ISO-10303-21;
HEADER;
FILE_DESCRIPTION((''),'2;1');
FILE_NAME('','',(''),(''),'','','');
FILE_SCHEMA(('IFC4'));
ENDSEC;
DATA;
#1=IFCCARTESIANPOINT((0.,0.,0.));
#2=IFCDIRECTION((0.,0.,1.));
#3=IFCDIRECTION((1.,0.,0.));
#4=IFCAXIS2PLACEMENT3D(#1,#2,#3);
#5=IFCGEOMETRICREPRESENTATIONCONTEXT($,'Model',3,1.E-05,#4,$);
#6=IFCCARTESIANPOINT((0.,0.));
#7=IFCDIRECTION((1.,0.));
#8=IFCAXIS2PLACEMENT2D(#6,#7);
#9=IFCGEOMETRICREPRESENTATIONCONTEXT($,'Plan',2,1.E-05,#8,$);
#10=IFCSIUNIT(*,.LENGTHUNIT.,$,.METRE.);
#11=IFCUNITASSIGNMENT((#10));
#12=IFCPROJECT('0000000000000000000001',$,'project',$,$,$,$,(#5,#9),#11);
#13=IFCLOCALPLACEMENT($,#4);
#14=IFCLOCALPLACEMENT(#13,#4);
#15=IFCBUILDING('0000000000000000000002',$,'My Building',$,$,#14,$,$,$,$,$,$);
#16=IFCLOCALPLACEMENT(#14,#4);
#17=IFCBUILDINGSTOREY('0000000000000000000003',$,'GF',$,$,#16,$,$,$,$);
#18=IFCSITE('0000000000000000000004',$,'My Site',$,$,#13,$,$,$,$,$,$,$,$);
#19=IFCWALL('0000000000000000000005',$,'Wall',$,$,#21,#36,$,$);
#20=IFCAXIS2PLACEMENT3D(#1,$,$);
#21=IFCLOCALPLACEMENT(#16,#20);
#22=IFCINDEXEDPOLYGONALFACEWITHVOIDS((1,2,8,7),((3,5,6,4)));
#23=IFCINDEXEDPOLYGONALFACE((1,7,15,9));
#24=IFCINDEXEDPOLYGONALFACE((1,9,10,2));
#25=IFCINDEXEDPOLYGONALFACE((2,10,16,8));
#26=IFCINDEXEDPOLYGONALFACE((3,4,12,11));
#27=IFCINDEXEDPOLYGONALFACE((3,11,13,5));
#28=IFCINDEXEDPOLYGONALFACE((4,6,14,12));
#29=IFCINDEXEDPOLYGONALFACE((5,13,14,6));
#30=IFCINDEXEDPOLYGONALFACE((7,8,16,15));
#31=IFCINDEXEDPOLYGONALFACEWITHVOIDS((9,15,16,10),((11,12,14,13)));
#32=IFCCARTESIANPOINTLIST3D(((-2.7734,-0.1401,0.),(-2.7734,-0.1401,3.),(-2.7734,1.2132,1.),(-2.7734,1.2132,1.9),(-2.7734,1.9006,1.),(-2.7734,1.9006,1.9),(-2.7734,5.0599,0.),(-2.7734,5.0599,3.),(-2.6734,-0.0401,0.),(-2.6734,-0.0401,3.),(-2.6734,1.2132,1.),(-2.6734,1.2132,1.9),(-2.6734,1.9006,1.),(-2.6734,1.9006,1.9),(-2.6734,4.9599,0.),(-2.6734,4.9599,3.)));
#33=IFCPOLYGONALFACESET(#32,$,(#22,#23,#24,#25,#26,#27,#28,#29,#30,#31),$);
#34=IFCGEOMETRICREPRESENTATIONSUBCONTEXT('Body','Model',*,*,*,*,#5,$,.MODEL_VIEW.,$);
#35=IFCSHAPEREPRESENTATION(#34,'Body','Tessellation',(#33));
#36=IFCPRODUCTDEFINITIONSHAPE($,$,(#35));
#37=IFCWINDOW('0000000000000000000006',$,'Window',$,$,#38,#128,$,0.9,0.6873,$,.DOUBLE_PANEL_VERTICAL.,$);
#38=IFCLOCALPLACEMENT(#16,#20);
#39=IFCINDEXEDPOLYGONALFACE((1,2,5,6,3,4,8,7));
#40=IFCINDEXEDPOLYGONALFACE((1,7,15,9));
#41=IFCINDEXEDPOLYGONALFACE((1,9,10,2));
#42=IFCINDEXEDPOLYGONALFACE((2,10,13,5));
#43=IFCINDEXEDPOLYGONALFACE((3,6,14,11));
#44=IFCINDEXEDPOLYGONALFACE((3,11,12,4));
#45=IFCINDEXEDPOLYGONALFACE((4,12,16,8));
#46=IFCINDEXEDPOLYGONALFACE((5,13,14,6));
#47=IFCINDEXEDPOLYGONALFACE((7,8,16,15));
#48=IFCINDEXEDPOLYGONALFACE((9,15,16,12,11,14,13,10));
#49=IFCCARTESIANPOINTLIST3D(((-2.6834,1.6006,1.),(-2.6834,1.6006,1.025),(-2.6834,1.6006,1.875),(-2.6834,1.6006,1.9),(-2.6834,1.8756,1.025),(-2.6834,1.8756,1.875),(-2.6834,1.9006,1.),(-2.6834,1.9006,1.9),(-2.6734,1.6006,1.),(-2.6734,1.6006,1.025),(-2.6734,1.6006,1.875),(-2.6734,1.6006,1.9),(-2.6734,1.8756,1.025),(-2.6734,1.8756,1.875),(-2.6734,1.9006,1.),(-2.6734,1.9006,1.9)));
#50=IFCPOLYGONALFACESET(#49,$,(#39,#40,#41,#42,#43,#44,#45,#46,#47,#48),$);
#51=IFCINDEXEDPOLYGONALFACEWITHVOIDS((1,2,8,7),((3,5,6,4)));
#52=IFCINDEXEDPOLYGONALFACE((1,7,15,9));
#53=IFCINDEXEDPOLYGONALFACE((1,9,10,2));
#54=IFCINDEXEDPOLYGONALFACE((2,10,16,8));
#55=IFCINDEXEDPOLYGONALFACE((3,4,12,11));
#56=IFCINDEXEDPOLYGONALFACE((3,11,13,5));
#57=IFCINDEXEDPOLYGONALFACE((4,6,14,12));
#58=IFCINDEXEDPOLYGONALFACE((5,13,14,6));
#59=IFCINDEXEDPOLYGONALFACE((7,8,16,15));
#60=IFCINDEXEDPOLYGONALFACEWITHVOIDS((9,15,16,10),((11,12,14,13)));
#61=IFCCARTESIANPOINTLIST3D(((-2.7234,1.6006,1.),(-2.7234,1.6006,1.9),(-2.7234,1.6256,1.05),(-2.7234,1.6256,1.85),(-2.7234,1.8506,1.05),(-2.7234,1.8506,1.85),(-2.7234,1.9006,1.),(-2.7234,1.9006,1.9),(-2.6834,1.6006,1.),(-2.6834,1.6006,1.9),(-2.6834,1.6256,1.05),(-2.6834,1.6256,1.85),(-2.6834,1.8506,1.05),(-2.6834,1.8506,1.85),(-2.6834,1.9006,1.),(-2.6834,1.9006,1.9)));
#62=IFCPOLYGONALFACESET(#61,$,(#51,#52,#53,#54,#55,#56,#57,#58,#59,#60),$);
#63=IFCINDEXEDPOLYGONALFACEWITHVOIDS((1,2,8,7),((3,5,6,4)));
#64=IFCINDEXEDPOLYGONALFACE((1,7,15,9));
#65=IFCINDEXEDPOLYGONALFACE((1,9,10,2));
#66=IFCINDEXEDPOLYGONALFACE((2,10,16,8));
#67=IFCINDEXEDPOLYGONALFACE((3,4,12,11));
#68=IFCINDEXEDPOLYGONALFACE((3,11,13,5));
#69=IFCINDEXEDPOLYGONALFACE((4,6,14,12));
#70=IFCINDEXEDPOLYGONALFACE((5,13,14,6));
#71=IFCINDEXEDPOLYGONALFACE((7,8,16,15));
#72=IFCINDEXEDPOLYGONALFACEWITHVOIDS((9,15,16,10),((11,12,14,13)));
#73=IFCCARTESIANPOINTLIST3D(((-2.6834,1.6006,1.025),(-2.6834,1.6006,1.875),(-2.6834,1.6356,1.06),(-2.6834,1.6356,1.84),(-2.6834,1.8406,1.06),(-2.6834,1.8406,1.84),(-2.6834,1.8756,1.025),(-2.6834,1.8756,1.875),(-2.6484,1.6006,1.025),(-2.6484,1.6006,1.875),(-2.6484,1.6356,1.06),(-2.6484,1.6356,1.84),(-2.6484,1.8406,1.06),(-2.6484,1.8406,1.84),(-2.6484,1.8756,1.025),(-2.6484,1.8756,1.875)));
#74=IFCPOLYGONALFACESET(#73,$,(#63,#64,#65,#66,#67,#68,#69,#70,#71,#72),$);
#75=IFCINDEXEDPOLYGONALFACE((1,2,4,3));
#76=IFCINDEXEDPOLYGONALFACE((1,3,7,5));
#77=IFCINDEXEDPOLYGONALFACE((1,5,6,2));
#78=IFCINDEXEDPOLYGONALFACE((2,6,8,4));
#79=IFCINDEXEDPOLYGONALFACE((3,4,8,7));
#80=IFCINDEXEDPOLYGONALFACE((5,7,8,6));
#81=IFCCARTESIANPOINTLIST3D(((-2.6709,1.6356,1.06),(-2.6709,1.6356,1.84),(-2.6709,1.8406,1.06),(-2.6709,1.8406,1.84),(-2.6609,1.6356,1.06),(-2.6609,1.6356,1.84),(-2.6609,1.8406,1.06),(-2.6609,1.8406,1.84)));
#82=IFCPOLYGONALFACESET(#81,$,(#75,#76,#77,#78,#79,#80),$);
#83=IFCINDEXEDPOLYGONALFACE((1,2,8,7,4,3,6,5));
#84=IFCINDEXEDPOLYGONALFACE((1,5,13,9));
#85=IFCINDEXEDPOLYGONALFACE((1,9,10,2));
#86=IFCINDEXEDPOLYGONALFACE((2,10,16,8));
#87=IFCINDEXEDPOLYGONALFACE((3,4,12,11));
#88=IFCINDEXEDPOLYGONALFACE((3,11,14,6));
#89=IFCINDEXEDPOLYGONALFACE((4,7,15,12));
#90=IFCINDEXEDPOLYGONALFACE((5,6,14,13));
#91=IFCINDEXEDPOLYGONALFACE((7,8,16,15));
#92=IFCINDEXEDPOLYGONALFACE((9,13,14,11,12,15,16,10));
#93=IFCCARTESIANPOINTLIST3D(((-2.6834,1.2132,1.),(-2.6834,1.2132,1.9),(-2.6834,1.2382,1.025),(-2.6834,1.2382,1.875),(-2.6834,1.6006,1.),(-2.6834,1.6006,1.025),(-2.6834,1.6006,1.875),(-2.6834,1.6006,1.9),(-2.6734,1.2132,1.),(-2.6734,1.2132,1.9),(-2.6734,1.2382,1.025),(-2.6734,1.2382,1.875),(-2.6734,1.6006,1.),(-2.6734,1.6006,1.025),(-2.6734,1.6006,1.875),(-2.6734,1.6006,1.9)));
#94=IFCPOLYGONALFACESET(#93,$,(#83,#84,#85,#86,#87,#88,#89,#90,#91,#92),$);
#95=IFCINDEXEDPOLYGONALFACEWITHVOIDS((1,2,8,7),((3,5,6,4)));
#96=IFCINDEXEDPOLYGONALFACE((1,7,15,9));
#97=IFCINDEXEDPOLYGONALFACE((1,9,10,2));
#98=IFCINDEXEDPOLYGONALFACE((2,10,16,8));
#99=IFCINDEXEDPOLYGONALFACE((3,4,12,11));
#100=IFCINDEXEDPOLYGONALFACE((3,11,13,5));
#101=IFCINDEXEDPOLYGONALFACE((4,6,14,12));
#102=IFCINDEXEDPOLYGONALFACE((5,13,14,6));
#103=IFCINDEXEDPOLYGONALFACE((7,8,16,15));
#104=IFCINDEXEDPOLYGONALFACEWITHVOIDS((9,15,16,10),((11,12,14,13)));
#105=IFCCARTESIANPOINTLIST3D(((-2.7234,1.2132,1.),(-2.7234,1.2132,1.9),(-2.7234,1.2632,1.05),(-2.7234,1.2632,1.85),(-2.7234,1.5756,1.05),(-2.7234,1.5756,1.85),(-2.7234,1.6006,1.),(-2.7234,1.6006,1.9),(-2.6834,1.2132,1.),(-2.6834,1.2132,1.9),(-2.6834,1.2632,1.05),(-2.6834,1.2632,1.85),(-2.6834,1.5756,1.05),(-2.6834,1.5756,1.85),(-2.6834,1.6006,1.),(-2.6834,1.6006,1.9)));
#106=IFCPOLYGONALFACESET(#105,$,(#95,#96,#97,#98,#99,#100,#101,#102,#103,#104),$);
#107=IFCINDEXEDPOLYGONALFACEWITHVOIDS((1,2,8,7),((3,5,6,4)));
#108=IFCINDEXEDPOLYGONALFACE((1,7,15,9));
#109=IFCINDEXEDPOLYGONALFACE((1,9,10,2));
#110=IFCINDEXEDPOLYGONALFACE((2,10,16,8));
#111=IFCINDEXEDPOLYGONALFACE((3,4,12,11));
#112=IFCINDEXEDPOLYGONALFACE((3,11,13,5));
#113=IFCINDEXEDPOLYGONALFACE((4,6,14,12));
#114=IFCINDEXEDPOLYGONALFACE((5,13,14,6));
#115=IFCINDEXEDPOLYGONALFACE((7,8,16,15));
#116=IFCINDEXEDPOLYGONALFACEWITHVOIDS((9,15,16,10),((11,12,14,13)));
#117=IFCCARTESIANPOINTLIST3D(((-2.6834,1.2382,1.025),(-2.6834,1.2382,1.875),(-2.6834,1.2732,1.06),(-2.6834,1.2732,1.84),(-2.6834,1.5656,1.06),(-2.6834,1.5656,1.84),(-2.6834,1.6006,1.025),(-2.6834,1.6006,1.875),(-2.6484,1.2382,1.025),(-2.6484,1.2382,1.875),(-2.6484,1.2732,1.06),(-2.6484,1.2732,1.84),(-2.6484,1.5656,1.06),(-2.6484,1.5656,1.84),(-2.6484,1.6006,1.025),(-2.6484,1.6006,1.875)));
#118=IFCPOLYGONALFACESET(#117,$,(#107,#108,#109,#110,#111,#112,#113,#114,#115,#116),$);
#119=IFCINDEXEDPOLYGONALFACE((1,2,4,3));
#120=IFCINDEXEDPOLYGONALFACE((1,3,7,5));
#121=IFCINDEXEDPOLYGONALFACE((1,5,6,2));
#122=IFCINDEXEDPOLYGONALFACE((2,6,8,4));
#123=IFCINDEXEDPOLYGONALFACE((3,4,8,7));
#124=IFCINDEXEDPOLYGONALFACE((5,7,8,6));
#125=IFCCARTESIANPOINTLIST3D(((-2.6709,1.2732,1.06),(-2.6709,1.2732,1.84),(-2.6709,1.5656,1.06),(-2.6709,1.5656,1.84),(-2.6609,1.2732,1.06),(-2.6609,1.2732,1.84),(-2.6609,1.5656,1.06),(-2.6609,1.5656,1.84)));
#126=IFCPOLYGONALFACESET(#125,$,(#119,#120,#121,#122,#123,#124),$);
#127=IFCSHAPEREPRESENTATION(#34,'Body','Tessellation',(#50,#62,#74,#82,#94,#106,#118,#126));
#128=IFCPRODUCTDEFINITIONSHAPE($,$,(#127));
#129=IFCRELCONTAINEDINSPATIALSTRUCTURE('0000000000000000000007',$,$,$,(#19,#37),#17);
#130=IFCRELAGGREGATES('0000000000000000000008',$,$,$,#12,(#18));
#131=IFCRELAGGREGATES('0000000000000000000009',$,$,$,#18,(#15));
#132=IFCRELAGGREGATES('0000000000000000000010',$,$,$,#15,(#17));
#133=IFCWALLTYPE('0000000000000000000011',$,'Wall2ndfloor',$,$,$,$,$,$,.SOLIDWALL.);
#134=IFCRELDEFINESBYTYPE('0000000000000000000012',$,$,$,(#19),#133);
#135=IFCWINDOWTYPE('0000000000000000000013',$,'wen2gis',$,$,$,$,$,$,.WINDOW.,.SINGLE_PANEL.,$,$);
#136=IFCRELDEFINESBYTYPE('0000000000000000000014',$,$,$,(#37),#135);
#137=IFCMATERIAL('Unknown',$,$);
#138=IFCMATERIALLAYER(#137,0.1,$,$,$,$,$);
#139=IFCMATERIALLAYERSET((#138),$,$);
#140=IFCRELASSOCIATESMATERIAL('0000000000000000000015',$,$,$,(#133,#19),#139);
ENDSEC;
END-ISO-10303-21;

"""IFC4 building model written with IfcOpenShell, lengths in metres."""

from ifc_helpers import new_model, entity, si_unit, frame, origin_with_axes, origin_2d_with_axis, place, context, subcontext, project, spatial, line, indexed_curve, outline, extrude, shape, source, transform, mapped, material, layer, layer_set, layer_usage, type_object, type_shapes, element, fill, save


model = new_model("IFC4")

# Units and contexts
model_context = context("Model", 3, precision=1e-05, world=origin_with_axes())
plan_context = context("Plan", 2, precision=1e-05, world=origin_2d_with_axis())
body_context_1 = subcontext(model_context, "Body", "Model", "MODEL_VIEW")
body_context_2 = subcontext(plan_context, "Body", "Plan", "PLAN_VIEW")
ifc_project = project(units=[si_unit("LENGTHUNIT", "METRE")], contexts=[model_context, plan_context])

# Site, building, storey
site_placement = place(None, origin_with_axes())
site = spatial("IfcSite", under=ifc_project, at=site_placement, Name="My Site")
building_placement = place(site_placement, origin_with_axes())
building = spatial("IfcBuilding", under=site, at=building_placement, Name="My Building")
storey_placement = place(building_placement, origin_with_axes())
storey = spatial("IfcBuildingStorey", under=building, at=storey_placement, Name="GF")

# Shared definitions
ifc_material = material(Name="Unknown")

# Shared definitions
ifc_layer_1 = layer(ifc_material, 0.1)
ifc_layer_set_1 = layer_set([ifc_layer_1])
wall_type_1 = type_object("IfcWallType", Name="Wall2ndfloor", PredefinedType="SOLIDWALL", material=ifc_layer_set_1)

# Wall, opening, window
ifc_layer_usage_1 = layer_usage(ifc_layer_set_1, "AXIS2", "POSITIVE", 0.0)
wall_1_placement = place(storey_placement, frame((-2.7734, 5.0599, 0.0), z_axis=(0.0, 0.0, 1.0), x_axis=(0.0, -1.0, 0.0)))
wall_1 = element("IfcWall", 1, at=wall_1_placement, inside=storey, type_object=wall_type_1, material=ifc_layer_usage_1, Name="Wall", context=body_context_1, shape_type="SweptSolid", body=[
    extrude(outline(indexed_curve([(0.0, 0.0), (0.1, 0.1), (5.1, 0.1), (5.2, 0.0)], segments=[line(1, 2, 3, 4, 1)])), origin_with_axes(), (0.0, 0.0, 1.0), 3.0),
])
shared_shape_1 = source(origin_with_axes(), body_context_1, "Body", "SweptSolid", [
    extrude(outline(indexed_curve([(0.0, 0.0), (0.6873, 0.0), (0.6873, 0.9), (0.0, 0.9)], segments=[line(1, 2, 3, 4, 1)])), frame((0.0, -0.6, 0.0), z_axis=(0.0, -1.0, 0.0), x_axis=(1.0, 0.0, 0.0)), (0.0, 0.0, -1.0), 1.2),
])
opening_1_placement = place(wall_1_placement, frame((3.1593, 0.0, 1.0), z_axis=(0.0, 0.0, 1.0), x_axis=(1.0, 0.0, 0.0)))
opening_1 = element("IfcOpeningElement", 2, at=opening_1_placement, cuts=wall_1, PredefinedType="OPENING", context=body_context_1, shape_type="MappedRepresentation", body=[
    mapped(shared_shape_1, transform((0.0, 0.0, 0.0), x_axis=(1.0, 0.0, 0.0), y_axis=(0.0, 1.0, 0.0), z_axis=(0.0, 0.0, 1.0), scale=1.0)),
])
window_type_1 = type_object("IfcWindowType", Name="wen2gis", PartitioningType="SINGLE_PANEL", PredefinedType="WINDOW")
shared_shape_2 = source(origin_with_axes(), body_context_1, "Body", "SweptSolid", [
    extrude(outline(indexed_curve([(0.3, 0.0), (0.0, 0.0), (0.0, 0.9), (0.3, 0.9), (0.3, 0.875), (0.025, 0.875), (0.025, 0.025), (0.3, 0.025)], segments=[line(1, 2, 3, 4, 5, 6, 7, 8, 1)])), frame((0.0, 0.09, 0.0), z_axis=(0.0, -1.0, 0.0), x_axis=(1.0, 0.0, 0.0)), (0.0, 0.0, -1.0), 0.01),
    extrude(outline(indexed_curve([(0.0, 0.0), (0.3, 0.0), (0.3, 0.9), (0.0, 0.9)], segments=[line(1, 2, 3, 4, 1)]), holes=[indexed_curve([(0.05, 0.05), (0.275, 0.05), (0.275, 0.85), (0.05, 0.85)], segments=[line(1, 2, 3, 4, 1)])]), frame((0.0, 0.05, 0.0), z_axis=(0.0, -1.0, 0.0), x_axis=(1.0, 0.0, 0.0)), (0.0, 0.0, -1.0), 0.04),
    extrude(outline(indexed_curve([(0.0, 0.0), (0.275, 0.0), (0.275, 0.85), (0.0, 0.85)], segments=[line(1, 2, 3, 4, 1)]), holes=[indexed_curve([(0.035, 0.035), (0.24, 0.035), (0.24, 0.815), (0.035, 0.815)], segments=[line(1, 2, 3, 4, 1)])]), frame((0.025, 0.09, 0.025), z_axis=(0.0, -1.0, 0.0), x_axis=(1.0, 0.0, 0.0)), (0.0, 0.0, -1.0), 0.035),
    extrude(outline(indexed_curve([(0.035, 0.035), (0.24, 0.035), (0.24, 0.815), (0.035, 0.815)], segments=[line(1, 2, 3, 4, 1)])), frame((0.025, 0.1025, 0.025), z_axis=(0.0, -1.0, 0.0), x_axis=(1.0, 0.0, 0.0)), (0.0, 0.0, -1.0), 0.01),
    extrude(outline(indexed_curve([(0.0, 0.9), (0.3873, 0.9), (0.3873, 0.0), (0.0, 0.0), (0.0, 0.025), (0.3623, 0.025), (0.3623, 0.875), (0.0, 0.875)], segments=[line(1, 2, 3, 4, 5, 6, 7, 8, 1)])), frame((0.3, 0.09, 0.0), z_axis=(0.0, -1.0, 0.0), x_axis=(1.0, 0.0, 0.0)), (0.0, 0.0, -1.0), 0.01),
    extrude(outline(indexed_curve([(0.0, 0.0), (0.3873, 0.0), (0.3873, 0.9), (0.0, 0.9)], segments=[line(1, 2, 3, 4, 1)]), holes=[indexed_curve([(0.025, 0.05), (0.3373, 0.05), (0.3373, 0.85), (0.025, 0.85)], segments=[line(1, 2, 3, 4, 1)])]), frame((0.3, 0.05, 0.0), z_axis=(0.0, -1.0, 0.0), x_axis=(1.0, 0.0, 0.0)), (0.0, 0.0, -1.0), 0.04),
    extrude(outline(indexed_curve([(0.0, 0.0), (0.3623, 0.0), (0.3623, 0.85), (0.0, 0.85)], segments=[line(1, 2, 3, 4, 1)]), holes=[indexed_curve([(0.035, 0.035), (0.3273, 0.035), (0.3273, 0.815), (0.035, 0.815)], segments=[line(1, 2, 3, 4, 1)])]), frame((0.3, 0.09, 0.025), z_axis=(0.0, -1.0, 0.0), x_axis=(1.0, 0.0, 0.0)), (0.0, 0.0, -1.0), 0.035),
    extrude(outline(indexed_curve([(0.035, 0.035), (0.3273, 0.035), (0.3273, 0.815), (0.035, 0.815)], segments=[line(1, 2, 3, 4, 1)])), frame((0.3, 0.1025, 0.025), z_axis=(0.0, -1.0, 0.0), x_axis=(1.0, 0.0, 0.0)), (0.0, 0.0, -1.0), 0.01),
])
shared_shape_3 = source(origin_with_axes(), body_context_2, "Body", "Curve2D", [
    entity("IfcIndexedPolyCurve", entity("IfcCartesianPointList2D", [[0.05, 0.05], [0.275, 0.05]])),
    entity("IfcIndexedPolyCurve", entity("IfcCartesianPointList2D", [[0.0, 0.1], [0.025, 0.1], [0.025, 0.09], [0.05, 0.09], [0.05, 0.05], [0.0, 0.05]]), [entity("IfcLineIndex", [1, 2, 3, 4, 5, 6, 1])]),
    entity("IfcIndexedPolyCurve", entity("IfcCartesianPointList2D", [[0.3, 0.1], [0.3, 0.1], [0.3, 0.09], [0.275, 0.09], [0.275, 0.05], [0.3, 0.05]])),
    entity("IfcIndexedPolyCurve", entity("IfcCartesianPointList2D", [[0.025, 0.09], [0.06, 0.09], [0.06, 0.125], [0.025, 0.125]]), [entity("IfcLineIndex", [1, 2, 3, 4, 1])]),
    entity("IfcIndexedPolyCurve", entity("IfcCartesianPointList2D", [[0.3, 0.09], [0.265, 0.09], [0.265, 0.125], [0.3, 0.125]]), [entity("IfcLineIndex", [1, 2, 3, 4, 1])]),
    entity("IfcIndexedPolyCurve", entity("IfcCartesianPointList2D", [[0.06, 0.09], [0.265, 0.09]])),
    entity("IfcIndexedPolyCurve", entity("IfcCartesianPointList2D", [[0.06, 0.125], [0.265, 0.125]])),
    entity("IfcIndexedPolyCurve", entity("IfcCartesianPointList2D", [[0.06, 0.1075], [0.265, 0.1075]])),
    entity("IfcIndexedPolyCurve", entity("IfcCartesianPointList2D", [[0.325, 0.05], [0.6373, 0.05]])),
    entity("IfcIndexedPolyCurve", entity("IfcCartesianPointList2D", [[0.3, 0.1], [0.3, 0.1], [0.3, 0.09], [0.325, 0.09], [0.325, 0.05], [0.3, 0.05]])),
    entity("IfcIndexedPolyCurve", entity("IfcCartesianPointList2D", [[0.6873, 0.1], [0.6623, 0.1], [0.6623, 0.09], [0.6373, 0.09], [0.6373, 0.05], [0.6873, 0.05]]), [entity("IfcLineIndex", [1, 2, 3, 4, 5, 6, 1])]),
    entity("IfcIndexedPolyCurve", entity("IfcCartesianPointList2D", [[0.3, 0.09], [0.335, 0.09], [0.335, 0.125], [0.3, 0.125]]), [entity("IfcLineIndex", [1, 2, 3, 4, 1])]),
    entity("IfcIndexedPolyCurve", entity("IfcCartesianPointList2D", [[0.6623, 0.09], [0.6273, 0.09], [0.6273, 0.125], [0.6623, 0.125]]), [entity("IfcLineIndex", [1, 2, 3, 4, 1])]),
    entity("IfcIndexedPolyCurve", entity("IfcCartesianPointList2D", [[0.335, 0.09], [0.6273, 0.09]])),
    entity("IfcIndexedPolyCurve", entity("IfcCartesianPointList2D", [[0.335, 0.125], [0.6273, 0.125]])),
    entity("IfcIndexedPolyCurve", entity("IfcCartesianPointList2D", [[0.335, 0.1075], [0.6273, 0.1075]])),
])
type_shapes(window_type_1, [shared_shape_2, shared_shape_3])
window_1_placement = place(opening_1_placement, frame((0.0, 0.0, 0.0), z_axis=(0.0, 0.0, 1.0), x_axis=(1.0, 0.0, 0.0)))
window_1 = element("IfcWindow", 3, at=window_1_placement, inside=storey, type_object=window_type_1, Name="Window", OverallHeight=0.9, OverallWidth=0.6873, PartitioningType="DOUBLE_PANEL_VERTICAL", shapes=[
    shape(body_context_1, "Body", "MappedRepresentation", [mapped(shared_shape_2, transform((0.0, 0.0, 0.0), x_axis=(1.0, 0.0, 0.0), y_axis=(0.0, 1.0, 0.0), z_axis=(0.0, 0.0, 1.0), scale=1.0))]),
    shape(body_context_2, "Body", "MappedRepresentation", [mapped(shared_shape_3, transform((0.0, 0.0, 0.0), x_axis=(1.0, 0.0, 0.0), y_axis=(0.0, 1.0, 0.0), z_axis=(0.0, 0.0, 1.0), scale=1.0))]),
])
fill(opening_1, window_1)

save(model, "model.ifc")
